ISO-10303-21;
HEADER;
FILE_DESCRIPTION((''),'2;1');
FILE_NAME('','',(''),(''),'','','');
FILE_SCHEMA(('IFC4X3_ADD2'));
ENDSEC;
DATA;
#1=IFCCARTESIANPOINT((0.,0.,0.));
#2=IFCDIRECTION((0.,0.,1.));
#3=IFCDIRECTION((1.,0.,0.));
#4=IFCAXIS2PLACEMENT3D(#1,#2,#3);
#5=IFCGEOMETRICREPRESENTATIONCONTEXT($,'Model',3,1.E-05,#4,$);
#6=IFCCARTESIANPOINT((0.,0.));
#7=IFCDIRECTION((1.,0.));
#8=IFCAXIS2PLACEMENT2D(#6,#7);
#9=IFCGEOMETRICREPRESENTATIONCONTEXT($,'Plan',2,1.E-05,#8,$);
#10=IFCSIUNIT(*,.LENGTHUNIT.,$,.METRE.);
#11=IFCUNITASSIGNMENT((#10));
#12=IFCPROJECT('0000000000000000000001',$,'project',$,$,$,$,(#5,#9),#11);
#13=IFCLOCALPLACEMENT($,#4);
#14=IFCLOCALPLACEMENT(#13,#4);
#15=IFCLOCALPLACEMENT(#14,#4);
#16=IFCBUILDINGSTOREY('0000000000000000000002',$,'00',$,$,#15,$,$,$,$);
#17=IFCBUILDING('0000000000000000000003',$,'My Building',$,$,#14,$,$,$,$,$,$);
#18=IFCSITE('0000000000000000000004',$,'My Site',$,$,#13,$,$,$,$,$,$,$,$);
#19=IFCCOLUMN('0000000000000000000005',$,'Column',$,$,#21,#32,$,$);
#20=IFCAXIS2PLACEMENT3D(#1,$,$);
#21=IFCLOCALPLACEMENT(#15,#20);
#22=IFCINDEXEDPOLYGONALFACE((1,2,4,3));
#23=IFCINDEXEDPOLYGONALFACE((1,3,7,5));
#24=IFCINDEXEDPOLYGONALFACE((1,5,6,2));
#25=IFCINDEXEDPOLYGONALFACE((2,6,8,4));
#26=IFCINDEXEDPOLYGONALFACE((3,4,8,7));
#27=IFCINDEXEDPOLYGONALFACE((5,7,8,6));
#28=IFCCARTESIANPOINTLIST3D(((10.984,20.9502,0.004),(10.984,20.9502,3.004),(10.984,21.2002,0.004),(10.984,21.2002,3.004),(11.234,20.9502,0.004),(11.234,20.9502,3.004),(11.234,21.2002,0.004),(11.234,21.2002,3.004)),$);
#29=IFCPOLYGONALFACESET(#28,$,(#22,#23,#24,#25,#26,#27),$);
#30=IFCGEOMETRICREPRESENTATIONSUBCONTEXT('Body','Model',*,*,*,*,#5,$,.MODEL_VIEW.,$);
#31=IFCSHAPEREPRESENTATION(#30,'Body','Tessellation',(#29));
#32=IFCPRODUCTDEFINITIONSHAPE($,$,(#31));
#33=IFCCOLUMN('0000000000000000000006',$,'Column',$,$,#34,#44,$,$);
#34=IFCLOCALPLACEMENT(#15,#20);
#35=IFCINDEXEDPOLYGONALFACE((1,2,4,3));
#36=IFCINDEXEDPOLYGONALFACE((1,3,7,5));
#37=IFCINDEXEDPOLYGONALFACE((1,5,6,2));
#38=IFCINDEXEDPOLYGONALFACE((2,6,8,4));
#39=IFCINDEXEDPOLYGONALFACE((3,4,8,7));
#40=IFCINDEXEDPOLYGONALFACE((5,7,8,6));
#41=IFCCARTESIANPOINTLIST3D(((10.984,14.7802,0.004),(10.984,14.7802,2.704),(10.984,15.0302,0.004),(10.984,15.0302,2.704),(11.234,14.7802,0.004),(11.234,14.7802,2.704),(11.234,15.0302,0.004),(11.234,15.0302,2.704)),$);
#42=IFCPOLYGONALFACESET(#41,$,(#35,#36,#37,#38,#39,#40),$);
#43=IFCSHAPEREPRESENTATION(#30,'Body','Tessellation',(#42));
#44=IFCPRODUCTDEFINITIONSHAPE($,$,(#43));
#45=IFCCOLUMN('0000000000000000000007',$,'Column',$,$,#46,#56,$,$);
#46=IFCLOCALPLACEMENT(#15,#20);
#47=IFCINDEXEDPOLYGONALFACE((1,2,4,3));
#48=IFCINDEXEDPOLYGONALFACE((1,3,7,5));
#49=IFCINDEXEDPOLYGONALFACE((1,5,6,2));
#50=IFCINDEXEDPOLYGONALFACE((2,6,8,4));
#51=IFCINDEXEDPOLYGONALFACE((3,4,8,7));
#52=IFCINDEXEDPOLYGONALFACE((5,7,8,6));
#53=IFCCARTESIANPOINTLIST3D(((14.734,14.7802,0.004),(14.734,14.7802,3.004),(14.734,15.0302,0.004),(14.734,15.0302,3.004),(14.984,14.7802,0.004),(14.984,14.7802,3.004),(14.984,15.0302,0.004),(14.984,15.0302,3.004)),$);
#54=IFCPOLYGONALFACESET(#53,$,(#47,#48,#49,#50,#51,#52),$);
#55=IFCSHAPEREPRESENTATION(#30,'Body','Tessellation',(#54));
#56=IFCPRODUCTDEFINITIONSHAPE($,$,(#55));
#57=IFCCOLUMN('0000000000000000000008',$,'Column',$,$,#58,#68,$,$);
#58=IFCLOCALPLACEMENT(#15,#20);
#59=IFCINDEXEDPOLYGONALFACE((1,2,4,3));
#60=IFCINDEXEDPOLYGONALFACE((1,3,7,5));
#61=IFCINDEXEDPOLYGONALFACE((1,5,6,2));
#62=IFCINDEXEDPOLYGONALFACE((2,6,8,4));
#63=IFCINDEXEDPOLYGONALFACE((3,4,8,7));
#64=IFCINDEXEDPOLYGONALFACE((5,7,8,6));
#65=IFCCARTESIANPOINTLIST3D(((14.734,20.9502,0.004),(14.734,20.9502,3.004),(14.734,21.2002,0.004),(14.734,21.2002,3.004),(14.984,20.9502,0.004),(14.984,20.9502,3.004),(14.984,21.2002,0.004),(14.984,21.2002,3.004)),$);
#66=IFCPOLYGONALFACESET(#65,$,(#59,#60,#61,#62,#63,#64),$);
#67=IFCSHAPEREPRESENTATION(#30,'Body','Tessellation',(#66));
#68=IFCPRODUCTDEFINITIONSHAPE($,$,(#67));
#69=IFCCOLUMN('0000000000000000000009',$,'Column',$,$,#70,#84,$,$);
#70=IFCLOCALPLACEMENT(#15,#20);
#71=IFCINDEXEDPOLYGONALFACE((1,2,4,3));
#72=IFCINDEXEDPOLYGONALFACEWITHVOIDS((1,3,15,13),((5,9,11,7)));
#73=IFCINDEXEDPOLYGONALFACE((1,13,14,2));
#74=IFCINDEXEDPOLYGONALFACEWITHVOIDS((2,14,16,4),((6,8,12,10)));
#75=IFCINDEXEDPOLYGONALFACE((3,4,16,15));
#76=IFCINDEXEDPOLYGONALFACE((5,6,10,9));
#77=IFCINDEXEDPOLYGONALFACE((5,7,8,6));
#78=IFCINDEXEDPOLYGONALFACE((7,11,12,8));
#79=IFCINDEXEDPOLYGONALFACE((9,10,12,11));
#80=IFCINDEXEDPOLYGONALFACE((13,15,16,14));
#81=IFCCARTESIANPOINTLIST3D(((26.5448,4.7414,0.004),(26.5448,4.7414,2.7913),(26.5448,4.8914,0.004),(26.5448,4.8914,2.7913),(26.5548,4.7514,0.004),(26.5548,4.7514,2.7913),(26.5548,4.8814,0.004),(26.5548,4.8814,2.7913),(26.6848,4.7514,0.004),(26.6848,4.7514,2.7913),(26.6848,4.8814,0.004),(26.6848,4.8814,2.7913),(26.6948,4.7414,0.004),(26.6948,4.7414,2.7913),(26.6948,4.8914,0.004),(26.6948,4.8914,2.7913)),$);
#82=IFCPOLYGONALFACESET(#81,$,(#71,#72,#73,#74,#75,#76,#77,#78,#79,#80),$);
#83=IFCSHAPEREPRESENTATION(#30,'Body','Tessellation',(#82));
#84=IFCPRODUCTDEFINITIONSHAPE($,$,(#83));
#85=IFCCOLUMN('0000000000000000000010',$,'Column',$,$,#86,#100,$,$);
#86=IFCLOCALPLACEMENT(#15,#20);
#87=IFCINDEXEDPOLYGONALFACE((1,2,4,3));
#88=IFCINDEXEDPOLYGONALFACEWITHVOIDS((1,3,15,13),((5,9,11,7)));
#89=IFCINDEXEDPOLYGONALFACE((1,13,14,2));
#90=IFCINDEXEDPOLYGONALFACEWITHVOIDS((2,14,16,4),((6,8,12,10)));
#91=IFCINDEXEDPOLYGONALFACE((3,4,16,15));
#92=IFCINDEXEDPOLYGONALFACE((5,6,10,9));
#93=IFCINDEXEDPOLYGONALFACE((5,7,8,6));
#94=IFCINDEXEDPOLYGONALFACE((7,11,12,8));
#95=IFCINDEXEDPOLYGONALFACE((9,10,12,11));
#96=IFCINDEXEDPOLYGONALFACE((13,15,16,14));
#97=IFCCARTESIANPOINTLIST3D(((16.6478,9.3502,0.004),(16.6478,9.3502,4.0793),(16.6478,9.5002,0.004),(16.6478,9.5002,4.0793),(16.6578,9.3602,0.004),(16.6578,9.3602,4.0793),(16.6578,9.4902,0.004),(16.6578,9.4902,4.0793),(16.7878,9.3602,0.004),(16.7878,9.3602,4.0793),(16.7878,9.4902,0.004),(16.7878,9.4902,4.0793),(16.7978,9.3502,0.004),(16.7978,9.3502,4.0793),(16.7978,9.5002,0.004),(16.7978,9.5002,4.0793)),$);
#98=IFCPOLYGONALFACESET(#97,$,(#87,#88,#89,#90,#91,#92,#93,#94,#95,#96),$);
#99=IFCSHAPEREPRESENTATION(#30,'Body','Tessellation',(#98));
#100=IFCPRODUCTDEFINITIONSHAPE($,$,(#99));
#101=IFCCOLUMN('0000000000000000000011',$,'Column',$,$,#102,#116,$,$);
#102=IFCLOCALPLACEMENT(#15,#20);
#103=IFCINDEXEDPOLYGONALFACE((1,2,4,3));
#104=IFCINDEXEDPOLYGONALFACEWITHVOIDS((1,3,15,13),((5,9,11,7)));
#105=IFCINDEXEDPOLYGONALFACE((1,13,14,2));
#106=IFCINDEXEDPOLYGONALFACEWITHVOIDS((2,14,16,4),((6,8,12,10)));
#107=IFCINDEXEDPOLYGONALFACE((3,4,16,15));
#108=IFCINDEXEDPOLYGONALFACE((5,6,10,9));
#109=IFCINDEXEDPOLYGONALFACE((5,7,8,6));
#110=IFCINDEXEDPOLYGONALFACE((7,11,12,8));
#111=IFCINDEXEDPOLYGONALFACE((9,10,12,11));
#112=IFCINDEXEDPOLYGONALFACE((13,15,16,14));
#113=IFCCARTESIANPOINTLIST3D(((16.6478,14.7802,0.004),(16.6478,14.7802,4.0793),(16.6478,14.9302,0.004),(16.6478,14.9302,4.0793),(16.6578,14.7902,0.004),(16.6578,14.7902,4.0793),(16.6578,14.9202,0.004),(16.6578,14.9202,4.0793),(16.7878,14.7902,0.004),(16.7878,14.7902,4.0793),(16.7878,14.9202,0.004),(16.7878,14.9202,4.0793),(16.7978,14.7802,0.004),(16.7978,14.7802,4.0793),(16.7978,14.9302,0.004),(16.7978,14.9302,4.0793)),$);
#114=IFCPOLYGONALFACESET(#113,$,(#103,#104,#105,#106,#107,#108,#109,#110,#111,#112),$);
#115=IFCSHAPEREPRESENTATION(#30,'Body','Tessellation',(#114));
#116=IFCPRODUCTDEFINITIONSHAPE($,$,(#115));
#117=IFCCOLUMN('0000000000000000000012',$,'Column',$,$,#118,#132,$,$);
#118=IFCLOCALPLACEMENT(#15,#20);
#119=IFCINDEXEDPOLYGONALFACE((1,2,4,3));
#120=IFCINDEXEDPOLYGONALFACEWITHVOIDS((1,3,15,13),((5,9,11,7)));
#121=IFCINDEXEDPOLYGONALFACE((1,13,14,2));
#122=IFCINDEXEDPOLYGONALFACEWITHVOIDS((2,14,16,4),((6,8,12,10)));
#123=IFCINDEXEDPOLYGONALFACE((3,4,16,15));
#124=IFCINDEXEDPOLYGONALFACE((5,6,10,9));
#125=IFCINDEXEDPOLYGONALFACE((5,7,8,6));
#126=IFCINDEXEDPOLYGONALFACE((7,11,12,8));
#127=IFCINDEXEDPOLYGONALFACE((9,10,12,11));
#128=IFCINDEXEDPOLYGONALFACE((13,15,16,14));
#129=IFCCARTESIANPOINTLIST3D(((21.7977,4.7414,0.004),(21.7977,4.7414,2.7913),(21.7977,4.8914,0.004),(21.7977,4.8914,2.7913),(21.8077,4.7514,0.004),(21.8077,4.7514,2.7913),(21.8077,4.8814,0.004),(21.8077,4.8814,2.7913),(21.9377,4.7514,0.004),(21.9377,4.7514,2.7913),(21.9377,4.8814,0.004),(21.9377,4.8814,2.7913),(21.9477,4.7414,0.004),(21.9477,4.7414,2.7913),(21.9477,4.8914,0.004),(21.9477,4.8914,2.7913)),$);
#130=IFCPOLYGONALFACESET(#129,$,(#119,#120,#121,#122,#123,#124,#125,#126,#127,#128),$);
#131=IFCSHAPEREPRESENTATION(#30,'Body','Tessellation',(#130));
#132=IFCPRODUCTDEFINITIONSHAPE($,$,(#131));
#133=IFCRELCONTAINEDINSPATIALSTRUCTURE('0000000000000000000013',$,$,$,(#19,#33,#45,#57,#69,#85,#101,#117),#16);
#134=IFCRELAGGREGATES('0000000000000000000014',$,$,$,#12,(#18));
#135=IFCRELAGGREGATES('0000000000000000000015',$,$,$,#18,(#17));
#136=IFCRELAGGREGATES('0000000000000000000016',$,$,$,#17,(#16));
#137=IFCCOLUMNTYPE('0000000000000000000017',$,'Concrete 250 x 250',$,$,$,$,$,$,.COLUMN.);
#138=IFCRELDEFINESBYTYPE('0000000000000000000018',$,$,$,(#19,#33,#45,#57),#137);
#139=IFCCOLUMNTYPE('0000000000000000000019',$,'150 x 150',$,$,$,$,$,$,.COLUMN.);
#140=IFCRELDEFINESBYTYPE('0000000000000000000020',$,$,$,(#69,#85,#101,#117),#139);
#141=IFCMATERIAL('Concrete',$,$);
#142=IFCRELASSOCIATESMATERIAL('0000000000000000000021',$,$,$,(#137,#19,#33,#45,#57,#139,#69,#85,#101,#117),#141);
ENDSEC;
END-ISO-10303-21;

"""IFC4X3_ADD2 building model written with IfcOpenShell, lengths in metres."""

from ifc_helpers import new_model, si_unit, frame, origin_with_axes, origin_2d_with_axis, place, context, subcontext, project, spatial, rectangle, hollow_rectangle, extrude, material, material_profile, profile_set, profile_usage, type_object, element, save


model = new_model("IFC4X3_ADD2")

# Units and contexts
model_context = context("Model", 3, precision=1e-05, world=origin_with_axes())
plan_context = context("Plan", 2, precision=1e-05, world=origin_2d_with_axis())
body_context = subcontext(model_context, "Body", "Model", "MODEL_VIEW")
ifc_project = project(units=[si_unit("LENGTHUNIT", "METRE")], contexts=[model_context, plan_context])

# Site, building, storey
site_placement = place(None, origin_with_axes())
site = spatial("IfcSite", under=ifc_project, at=site_placement, Name="My Site")
building_placement = place(site_placement, origin_with_axes())
building = spatial("IfcBuilding", under=site, at=building_placement, Name="My Building")
storey_placement = place(building_placement, origin_with_axes())
storey = spatial("IfcBuildingStorey", under=building, at=storey_placement, Name="00")

# Columns
ifc_material_1 = material(Name="Concrete")
ifc_material_profile_1 = material_profile(ifc_material_1, rectangle(XDim=0.25, YDim=0.25))
ifc_profile_set_1 = profile_set([ifc_material_profile_1])
ifc_profile_usage_1 = profile_usage(ifc_profile_set_1, cardinal=5)
column_type_1 = type_object("IfcColumnType", Name="Concrete 250 x 250", PredefinedType="COLUMN", material=ifc_profile_set_1)
column_1_placement = place(storey_placement, frame((11.109, 21.0752, 0.004), z_axis=(0.0, 0.0, 1.0), x_axis=(1.0, 0.0, 0.0)))
element("IfcColumn", 1, at=column_1_placement, inside=storey, type_object=column_type_1, material=ifc_profile_usage_1, Name="Column", context=body_context, shape_type="SweptSolid", body=[
    extrude(rectangle(XDim=0.25, YDim=0.25), origin_with_axes(), (0.0, 0.0, 1.0), 3.0),
])
ifc_profile_usage_2 = profile_usage(ifc_profile_set_1, cardinal=5)
column_2_placement = place(storey_placement, frame((11.109, 14.9052, 0.004), z_axis=(0.0, 0.0, 1.0), x_axis=(1.0, 0.0, 0.0)))
element("IfcColumn", 2, at=column_2_placement, inside=storey, type_object=column_type_1, material=ifc_profile_usage_2, Name="Column", context=body_context, shape_type="SweptSolid", body=[
    extrude(rectangle(XDim=0.25, YDim=0.25), origin_with_axes(), (0.0, 0.0, 1.0), 2.7),
])
ifc_profile_usage_3 = profile_usage(ifc_profile_set_1, cardinal=5)
column_3_placement = place(storey_placement, frame((14.859, 14.9052, 0.004), z_axis=(0.0, 0.0, 1.0), x_axis=(1.0, 0.0, 0.0)))
element("IfcColumn", 3, at=column_3_placement, inside=storey, type_object=column_type_1, material=ifc_profile_usage_3, Name="Column", context=body_context, shape_type="SweptSolid", body=[
    extrude(rectangle(XDim=0.25, YDim=0.25), origin_with_axes(), (0.0, 0.0, 1.0), 3.0),
])
ifc_profile_usage_4 = profile_usage(ifc_profile_set_1, cardinal=5)
column_4_placement = place(storey_placement, frame((14.859, 21.0752, 0.004), z_axis=(0.0, 0.0, 1.0), x_axis=(1.0, 0.0, 0.0)))
element("IfcColumn", 4, at=column_4_placement, inside=storey, type_object=column_type_1, material=ifc_profile_usage_4, Name="Column", context=body_context, shape_type="SweptSolid", body=[
    extrude(rectangle(XDim=0.25, YDim=0.25), origin_with_axes(), (0.0, 0.0, 1.0), 3.0),
])
ifc_material_profile_2 = material_profile(ifc_material_1, hollow_rectangle(XDim=0.15, YDim=0.15, WallThickness=0.01))
ifc_profile_set_2 = profile_set([ifc_material_profile_2])
ifc_profile_usage_5 = profile_usage(ifc_profile_set_2, cardinal=5)
column_type_2 = type_object("IfcColumnType", Name="150 x 150", PredefinedType="COLUMN", material=ifc_profile_set_2)
column_5_placement = place(storey_placement, frame((26.6198, 4.8164, 0.004), z_axis=(0.0, 0.0, 1.0), x_axis=(1.0, 0.0, 0.0)))
element("IfcColumn", 5, at=column_5_placement, inside=storey, type_object=column_type_2, material=ifc_profile_usage_5, Name="Column", context=body_context, shape_type="SweptSolid", body=[
    extrude(hollow_rectangle(XDim=0.15, YDim=0.15, WallThickness=0.01), origin_with_axes(), (0.0, 0.0, 1.0), 2.7873),
])
ifc_profile_usage_6 = profile_usage(ifc_profile_set_2, cardinal=5)
column_6_placement = place(storey_placement, frame((16.7228, 9.4252, 0.004), z_axis=(0.0, 0.0, 1.0), x_axis=(1.0, 0.0, 0.0)))
element("IfcColumn", 6, at=column_6_placement, inside=storey, type_object=column_type_2, material=ifc_profile_usage_6, Name="Column", context=body_context, shape_type="SweptSolid", body=[
    extrude(hollow_rectangle(XDim=0.15, YDim=0.15, WallThickness=0.01), origin_with_axes(), (0.0, 0.0, 1.0), 4.0753),
])
ifc_profile_usage_7 = profile_usage(ifc_profile_set_2, cardinal=5)
column_7_placement = place(storey_placement, frame((16.7228, 14.8552, 0.004), z_axis=(0.0, 0.0, 1.0), x_axis=(1.0, 0.0, 0.0)))
element("IfcColumn", 7, at=column_7_placement, inside=storey, type_object=column_type_2, material=ifc_profile_usage_7, Name="Column", context=body_context, shape_type="SweptSolid", body=[
    extrude(hollow_rectangle(XDim=0.15, YDim=0.15, WallThickness=0.01), origin_with_axes(), (0.0, 0.0, 1.0), 4.0753),
])
ifc_profile_usage_8 = profile_usage(ifc_profile_set_2, cardinal=5)
column_8_placement = place(storey_placement, frame((21.8727, 4.8164, 0.004), z_axis=(0.0, 0.0, 1.0), x_axis=(1.0, 0.0, 0.0)))
element("IfcColumn", 8, at=column_8_placement, inside=storey, type_object=column_type_2, material=ifc_profile_usage_8, Name="Column", context=body_context, shape_type="SweptSolid", body=[
    extrude(hollow_rectangle(XDim=0.15, YDim=0.15, WallThickness=0.01), origin_with_axes(), (0.0, 0.0, 1.0), 2.7873),
])

save(model, "model.ifc")
